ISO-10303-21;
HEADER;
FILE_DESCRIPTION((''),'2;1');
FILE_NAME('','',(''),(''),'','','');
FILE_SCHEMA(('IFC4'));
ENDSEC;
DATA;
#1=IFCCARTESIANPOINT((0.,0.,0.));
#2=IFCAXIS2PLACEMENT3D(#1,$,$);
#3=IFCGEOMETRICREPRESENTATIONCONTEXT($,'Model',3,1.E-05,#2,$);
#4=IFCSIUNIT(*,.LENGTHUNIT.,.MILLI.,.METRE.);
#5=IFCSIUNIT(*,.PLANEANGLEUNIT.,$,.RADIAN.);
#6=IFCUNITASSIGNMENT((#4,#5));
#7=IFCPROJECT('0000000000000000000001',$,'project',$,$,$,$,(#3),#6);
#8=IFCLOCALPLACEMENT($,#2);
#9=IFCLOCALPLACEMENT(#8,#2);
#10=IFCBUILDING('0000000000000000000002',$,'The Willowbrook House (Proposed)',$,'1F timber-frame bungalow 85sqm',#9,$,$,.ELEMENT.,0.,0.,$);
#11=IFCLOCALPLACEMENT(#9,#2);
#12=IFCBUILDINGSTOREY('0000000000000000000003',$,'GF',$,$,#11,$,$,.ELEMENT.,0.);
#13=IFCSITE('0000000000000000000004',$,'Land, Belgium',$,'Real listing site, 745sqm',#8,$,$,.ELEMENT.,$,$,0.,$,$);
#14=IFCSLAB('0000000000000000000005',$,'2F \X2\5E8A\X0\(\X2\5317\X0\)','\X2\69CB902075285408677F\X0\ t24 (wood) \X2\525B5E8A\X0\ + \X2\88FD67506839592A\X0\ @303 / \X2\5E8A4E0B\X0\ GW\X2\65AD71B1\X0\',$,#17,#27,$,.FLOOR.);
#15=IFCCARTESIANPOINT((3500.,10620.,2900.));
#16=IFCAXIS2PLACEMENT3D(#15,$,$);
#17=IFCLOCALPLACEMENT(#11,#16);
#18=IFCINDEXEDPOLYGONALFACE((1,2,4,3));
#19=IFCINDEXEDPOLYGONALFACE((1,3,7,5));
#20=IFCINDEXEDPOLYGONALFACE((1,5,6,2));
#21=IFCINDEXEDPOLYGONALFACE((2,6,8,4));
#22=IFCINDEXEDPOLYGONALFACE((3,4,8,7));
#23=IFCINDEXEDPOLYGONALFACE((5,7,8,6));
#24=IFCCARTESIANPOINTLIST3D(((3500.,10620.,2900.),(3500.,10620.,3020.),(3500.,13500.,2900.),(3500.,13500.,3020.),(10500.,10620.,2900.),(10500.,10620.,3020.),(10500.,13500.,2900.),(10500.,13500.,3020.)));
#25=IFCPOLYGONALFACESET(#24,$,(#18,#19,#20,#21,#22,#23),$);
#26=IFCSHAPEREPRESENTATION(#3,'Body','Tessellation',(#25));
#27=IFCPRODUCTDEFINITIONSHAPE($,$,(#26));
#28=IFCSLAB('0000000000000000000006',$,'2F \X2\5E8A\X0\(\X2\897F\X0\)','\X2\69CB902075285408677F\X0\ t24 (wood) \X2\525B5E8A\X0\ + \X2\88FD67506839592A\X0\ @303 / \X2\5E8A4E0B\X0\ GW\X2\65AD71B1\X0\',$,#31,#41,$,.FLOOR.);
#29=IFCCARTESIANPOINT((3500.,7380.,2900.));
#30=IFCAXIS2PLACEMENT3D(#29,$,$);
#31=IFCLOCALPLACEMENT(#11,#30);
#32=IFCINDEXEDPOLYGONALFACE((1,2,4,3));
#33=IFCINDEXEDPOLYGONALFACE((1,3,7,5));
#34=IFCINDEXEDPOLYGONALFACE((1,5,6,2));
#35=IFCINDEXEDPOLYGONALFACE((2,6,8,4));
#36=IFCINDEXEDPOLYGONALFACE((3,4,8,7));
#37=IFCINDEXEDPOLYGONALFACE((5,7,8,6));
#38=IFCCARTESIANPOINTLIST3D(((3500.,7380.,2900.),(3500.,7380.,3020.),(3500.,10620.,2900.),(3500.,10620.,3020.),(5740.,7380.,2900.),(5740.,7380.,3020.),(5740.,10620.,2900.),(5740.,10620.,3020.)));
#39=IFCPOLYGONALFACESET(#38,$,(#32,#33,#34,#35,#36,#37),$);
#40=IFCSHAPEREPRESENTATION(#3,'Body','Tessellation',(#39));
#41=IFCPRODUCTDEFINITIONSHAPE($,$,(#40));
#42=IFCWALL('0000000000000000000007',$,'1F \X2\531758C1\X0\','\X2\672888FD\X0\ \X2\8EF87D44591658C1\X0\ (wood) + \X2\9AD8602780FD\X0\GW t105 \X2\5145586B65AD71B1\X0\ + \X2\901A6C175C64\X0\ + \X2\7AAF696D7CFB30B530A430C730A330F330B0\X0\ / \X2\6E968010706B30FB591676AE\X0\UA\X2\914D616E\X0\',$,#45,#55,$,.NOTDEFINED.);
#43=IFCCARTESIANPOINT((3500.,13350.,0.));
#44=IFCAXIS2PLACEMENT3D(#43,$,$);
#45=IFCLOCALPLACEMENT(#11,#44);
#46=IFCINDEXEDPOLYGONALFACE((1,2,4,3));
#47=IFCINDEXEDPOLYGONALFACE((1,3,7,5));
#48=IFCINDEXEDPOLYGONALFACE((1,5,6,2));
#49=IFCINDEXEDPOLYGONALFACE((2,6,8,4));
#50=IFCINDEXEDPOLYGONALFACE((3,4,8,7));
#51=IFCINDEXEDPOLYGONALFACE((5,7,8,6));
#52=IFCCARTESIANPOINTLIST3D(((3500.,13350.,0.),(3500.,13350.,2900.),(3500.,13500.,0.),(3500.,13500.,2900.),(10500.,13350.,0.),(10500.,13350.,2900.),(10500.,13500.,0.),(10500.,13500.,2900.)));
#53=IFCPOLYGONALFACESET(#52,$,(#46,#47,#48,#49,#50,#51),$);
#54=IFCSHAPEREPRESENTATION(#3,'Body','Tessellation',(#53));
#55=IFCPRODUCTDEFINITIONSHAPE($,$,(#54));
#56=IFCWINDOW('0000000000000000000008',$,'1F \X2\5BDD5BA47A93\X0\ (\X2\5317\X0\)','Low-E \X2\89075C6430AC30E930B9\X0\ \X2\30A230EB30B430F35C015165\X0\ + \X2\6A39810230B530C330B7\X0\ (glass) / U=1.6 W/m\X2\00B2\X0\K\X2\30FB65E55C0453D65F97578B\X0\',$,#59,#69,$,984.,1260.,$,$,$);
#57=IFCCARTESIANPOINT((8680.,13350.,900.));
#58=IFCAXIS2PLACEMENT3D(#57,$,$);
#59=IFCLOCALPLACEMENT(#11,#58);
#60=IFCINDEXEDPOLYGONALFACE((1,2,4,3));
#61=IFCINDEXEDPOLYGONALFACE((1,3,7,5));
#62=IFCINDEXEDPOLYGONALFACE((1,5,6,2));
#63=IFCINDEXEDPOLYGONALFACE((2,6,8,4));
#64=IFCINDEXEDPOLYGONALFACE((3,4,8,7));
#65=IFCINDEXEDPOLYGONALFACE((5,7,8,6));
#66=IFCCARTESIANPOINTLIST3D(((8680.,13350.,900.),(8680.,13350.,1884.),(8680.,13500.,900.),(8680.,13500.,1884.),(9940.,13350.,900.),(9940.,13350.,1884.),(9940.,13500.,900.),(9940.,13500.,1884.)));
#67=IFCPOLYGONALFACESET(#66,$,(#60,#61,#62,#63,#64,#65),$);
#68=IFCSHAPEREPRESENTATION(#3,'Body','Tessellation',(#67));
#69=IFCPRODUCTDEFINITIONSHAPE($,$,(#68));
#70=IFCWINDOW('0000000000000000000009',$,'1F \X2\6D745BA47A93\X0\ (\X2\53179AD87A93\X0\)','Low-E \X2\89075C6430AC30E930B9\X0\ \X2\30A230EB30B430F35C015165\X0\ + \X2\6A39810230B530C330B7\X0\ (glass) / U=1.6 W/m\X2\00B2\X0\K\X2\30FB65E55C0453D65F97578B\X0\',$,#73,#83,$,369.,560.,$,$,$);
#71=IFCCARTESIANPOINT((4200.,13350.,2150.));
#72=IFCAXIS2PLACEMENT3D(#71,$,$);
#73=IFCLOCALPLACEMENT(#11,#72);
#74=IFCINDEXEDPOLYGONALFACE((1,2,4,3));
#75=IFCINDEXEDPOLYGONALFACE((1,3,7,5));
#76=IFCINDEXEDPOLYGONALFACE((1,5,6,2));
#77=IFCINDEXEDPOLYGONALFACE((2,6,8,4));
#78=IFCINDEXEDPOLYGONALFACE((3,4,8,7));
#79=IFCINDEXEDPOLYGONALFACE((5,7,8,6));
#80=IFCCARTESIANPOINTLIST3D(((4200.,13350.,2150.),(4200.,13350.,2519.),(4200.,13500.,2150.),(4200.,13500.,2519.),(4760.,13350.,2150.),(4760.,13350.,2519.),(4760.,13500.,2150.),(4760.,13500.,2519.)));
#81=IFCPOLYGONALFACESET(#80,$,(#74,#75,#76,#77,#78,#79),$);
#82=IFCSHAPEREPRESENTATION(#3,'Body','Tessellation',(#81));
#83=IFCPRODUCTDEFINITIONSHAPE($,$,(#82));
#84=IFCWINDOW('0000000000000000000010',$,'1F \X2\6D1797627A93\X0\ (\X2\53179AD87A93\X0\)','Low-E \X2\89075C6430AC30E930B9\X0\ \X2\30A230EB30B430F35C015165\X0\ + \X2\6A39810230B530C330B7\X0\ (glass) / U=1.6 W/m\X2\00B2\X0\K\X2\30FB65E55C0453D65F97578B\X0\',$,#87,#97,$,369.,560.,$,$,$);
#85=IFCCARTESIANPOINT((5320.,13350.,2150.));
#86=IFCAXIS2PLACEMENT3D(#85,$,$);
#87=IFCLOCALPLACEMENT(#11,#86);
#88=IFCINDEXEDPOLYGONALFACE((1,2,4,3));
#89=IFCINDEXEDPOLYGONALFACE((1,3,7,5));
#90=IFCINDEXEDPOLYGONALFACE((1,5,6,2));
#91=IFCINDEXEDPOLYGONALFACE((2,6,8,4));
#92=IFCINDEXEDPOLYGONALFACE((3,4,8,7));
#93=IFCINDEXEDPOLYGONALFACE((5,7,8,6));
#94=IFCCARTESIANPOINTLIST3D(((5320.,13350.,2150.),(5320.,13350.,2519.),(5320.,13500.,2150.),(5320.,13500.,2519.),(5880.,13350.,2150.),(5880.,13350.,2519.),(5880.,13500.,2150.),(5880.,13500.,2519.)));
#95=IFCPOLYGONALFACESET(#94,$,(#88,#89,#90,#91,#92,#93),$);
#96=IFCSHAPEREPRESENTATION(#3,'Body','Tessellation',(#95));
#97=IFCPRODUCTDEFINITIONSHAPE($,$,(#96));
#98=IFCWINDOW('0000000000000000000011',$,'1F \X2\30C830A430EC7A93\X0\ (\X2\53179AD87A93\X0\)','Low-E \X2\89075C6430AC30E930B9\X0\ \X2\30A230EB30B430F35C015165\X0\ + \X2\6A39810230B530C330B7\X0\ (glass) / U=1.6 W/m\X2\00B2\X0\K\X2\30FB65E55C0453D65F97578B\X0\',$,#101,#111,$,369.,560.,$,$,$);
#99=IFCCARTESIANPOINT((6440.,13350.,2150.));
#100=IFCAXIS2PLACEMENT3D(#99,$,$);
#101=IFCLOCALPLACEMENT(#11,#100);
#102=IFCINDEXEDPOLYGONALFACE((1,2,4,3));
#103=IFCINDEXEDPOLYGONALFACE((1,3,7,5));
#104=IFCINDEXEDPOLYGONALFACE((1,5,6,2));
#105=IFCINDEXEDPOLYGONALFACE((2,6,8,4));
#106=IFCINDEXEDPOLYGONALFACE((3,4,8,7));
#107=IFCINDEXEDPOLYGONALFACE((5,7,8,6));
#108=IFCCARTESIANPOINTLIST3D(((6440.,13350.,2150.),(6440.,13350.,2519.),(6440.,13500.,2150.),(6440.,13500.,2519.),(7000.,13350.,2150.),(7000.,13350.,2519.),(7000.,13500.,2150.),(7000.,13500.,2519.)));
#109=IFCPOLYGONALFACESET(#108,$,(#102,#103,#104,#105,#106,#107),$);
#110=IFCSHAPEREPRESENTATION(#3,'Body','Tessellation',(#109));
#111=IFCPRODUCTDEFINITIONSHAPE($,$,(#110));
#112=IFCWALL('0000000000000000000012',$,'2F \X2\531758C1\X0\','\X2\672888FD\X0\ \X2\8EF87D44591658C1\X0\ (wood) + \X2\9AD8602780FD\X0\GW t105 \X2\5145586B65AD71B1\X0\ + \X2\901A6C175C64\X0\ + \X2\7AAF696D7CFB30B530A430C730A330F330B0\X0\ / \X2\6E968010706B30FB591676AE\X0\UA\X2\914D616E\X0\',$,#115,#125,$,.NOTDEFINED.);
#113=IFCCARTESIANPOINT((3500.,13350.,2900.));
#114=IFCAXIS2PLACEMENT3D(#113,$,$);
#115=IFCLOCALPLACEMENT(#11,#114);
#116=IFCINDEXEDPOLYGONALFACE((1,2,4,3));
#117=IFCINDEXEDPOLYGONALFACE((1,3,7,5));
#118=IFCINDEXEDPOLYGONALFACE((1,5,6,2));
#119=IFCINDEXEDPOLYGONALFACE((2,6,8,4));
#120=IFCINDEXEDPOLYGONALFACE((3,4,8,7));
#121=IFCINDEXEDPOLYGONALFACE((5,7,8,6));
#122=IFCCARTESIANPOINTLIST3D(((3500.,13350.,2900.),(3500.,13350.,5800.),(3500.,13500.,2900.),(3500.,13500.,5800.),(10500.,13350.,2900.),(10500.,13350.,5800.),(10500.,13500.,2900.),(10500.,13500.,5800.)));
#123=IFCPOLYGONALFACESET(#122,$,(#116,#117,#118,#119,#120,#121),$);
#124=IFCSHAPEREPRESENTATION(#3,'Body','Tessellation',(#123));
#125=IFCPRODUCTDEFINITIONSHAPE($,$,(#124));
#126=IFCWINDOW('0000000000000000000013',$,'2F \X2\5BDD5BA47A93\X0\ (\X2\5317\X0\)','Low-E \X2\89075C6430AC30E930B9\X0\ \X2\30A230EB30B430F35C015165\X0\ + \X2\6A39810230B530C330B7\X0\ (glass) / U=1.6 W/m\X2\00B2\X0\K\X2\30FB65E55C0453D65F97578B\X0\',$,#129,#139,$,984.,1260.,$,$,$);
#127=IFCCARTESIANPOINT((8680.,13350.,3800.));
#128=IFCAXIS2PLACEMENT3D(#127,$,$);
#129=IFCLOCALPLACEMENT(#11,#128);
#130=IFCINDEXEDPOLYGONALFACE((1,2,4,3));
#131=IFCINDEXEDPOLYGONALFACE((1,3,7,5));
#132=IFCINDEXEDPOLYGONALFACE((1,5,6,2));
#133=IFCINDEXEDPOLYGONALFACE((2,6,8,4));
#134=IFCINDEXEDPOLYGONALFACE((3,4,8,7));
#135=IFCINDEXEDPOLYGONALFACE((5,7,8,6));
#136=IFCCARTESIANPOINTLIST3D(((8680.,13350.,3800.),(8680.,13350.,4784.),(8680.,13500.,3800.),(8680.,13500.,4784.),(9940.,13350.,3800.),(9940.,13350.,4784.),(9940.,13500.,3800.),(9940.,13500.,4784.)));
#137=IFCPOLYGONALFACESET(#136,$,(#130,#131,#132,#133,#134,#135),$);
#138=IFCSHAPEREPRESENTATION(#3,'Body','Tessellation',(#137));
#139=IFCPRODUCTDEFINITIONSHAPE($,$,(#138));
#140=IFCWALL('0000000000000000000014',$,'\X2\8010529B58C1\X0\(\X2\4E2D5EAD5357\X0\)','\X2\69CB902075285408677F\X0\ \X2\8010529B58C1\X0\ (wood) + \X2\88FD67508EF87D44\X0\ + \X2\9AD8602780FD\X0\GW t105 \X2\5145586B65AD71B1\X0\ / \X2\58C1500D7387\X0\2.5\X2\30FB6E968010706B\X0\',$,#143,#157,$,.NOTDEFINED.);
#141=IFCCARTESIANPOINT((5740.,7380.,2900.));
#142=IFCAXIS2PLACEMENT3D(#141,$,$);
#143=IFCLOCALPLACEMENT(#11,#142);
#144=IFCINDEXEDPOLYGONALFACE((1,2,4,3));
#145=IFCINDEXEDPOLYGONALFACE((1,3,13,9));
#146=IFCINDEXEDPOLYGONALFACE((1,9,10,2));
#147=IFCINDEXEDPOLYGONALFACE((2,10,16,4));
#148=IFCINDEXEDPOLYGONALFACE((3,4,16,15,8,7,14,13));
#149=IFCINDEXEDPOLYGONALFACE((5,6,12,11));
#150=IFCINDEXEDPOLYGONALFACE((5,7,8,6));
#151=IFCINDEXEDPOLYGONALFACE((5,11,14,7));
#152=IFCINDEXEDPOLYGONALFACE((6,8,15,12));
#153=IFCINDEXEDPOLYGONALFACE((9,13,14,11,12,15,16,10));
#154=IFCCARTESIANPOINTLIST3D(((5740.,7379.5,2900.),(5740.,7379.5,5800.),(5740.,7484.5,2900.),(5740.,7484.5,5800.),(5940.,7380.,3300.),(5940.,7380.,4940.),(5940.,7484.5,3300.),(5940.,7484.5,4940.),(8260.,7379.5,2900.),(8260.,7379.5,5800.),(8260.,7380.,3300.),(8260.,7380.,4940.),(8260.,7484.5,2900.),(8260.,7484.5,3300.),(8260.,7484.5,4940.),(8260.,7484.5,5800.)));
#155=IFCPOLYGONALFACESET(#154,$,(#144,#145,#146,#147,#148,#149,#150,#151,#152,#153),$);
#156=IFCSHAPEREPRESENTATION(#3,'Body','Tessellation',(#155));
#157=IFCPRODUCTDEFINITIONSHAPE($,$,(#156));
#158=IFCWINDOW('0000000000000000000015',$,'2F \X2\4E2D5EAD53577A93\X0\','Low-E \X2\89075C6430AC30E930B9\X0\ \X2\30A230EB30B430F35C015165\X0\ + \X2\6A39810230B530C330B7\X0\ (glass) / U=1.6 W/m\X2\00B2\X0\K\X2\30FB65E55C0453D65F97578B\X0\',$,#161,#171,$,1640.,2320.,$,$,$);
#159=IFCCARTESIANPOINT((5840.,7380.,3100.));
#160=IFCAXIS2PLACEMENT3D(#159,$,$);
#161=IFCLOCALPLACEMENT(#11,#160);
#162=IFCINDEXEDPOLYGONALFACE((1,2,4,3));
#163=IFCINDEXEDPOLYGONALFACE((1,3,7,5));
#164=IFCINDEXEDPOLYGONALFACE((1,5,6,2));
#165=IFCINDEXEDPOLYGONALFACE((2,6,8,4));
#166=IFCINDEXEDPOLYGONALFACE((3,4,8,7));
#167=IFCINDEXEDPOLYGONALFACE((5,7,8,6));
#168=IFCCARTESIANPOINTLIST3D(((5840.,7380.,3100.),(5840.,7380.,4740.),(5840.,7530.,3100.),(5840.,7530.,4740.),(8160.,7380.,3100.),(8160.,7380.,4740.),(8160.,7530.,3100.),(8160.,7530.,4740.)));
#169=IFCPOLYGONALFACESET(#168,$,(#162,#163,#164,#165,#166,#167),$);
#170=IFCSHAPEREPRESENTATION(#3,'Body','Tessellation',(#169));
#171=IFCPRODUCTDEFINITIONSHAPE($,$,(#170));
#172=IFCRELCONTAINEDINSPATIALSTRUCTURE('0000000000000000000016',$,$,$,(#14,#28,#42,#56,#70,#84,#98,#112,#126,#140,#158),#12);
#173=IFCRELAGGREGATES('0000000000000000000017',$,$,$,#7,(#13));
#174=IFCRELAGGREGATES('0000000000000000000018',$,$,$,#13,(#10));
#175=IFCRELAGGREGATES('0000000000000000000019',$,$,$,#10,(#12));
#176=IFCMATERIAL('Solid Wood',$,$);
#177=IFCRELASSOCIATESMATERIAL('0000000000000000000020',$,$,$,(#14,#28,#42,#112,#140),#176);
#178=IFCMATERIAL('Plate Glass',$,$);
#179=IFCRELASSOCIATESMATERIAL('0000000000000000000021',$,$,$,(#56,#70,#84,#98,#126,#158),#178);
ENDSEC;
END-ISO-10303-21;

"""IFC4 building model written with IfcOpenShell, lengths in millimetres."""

from ifc_helpers import new_model, si_unit, frame, frame_2d, origin, place, context, project, spatial, rectangle, extrude, material, element, fill, save


model = new_model("IFC4")

# Units and contexts
model_context = context("Model", 3, precision=1e-05, world=origin())
ifc_project = project(units=[si_unit("LENGTHUNIT", "METRE", prefix="MILLI"), si_unit("PLANEANGLEUNIT", "RADIAN")], contexts=[model_context])

# Site, building, storey
site_placement = place(None, origin())
site = spatial("IfcSite", under=ifc_project, at=site_placement, Name="Land, Belgium", ObjectType="Real listing site, 745sqm", CompositionType="ELEMENT", RefElevation=0.0)
building_placement = place(site_placement, origin())
building = spatial("IfcBuilding", under=site, at=building_placement, Name="The Willowbrook House (Proposed)", ObjectType="1F timber-frame bungalow 85sqm", CompositionType="ELEMENT", ElevationOfRefHeight=0.0, ElevationOfTerrain=0.0)
storey_placement = place(building_placement, origin())
storey = spatial("IfcBuildingStorey", under=building, at=storey_placement, Name="GF", CompositionType="ELEMENT", Elevation=0.0)

# Slabs
ifc_material_1 = material(Name="Solid Wood")
slab_1_placement = place(storey_placement, frame((3500.0, 10620.0, 2900.0)))
element("IfcSlab", 1, at=slab_1_placement, inside=storey, material=ifc_material_1, Name="2F 床(北)", Description="構造用合板 t24 (wood) 剛床 + 製材根太 @303 / 床下 GW断熱", PredefinedType="FLOOR", context=model_context, shape_type="SweptSolid", body=[
    extrude(rectangle(XDim=7000.0, YDim=2880.0, at=frame_2d((3500.0, 1440.0))), frame((3500.0, 10620.0, 2900.0)), (0.0, 0.0, 1.0), 120.0),
])
slab_2_placement = place(storey_placement, frame((3500.0, 7380.0, 2900.0)))
element("IfcSlab", 2, at=slab_2_placement, inside=storey, material=ifc_material_1, Name="2F 床(西)", Description="構造用合板 t24 (wood) 剛床 + 製材根太 @303 / 床下 GW断熱", PredefinedType="FLOOR", context=model_context, shape_type="SweptSolid", body=[
    extrude(rectangle(XDim=2240.0, YDim=3240.0, at=frame_2d((1120.0, 1620.0))), frame((3500.0, 7380.0, 2900.0)), (0.0, 0.0, 1.0), 120.0),
])

# Wall, openings, windows
wall_1_placement = place(storey_placement, frame((3500.0, 13350.0, 0.0)))
wall_1 = element("IfcWall", 3, at=wall_1_placement, inside=storey, material=ifc_material_1, Name="1F 北壁", Description="木製 軸組外壁 (wood) + 高性能GW t105 充填断熱 + 通気層 + 窯業系サイディング / 準耐火・外皮UA配慮", PredefinedType="NOTDEFINED", context=model_context, shape_type="SweptSolid", body=[
    extrude(rectangle(XDim=7000.0, YDim=150.0, at=frame_2d((3500.0, 75.0))), frame((3500.0, 13350.0, 0.0)), (0.0, 0.0, 1.0), 2900.0),
])
opening_1_placement = place(storey_placement, frame((8680.0, 13350.0, 900.0)))
opening_1 = element("IfcOpeningElement", 4, at=opening_1_placement, cuts=wall_1, PredefinedType="NOTDEFINED", context=model_context, shape_type="SweptSolid", body=[
    extrude(rectangle(XDim=1260.0, YDim=150.0, at=frame_2d((630.0, 75.0))), frame((8680.0, 13350.0, 900.0)), (0.0, 0.0, 1.0), 984.0),
])
opening_2_placement = place(storey_placement, frame((4200.0, 13350.0, 2150.0)))
opening_2 = element("IfcOpeningElement", 5, at=opening_2_placement, cuts=wall_1, PredefinedType="NOTDEFINED", context=model_context, shape_type="SweptSolid", body=[
    extrude(rectangle(XDim=560.0, YDim=150.0, at=frame_2d((280.0, 75.0))), frame((4200.0, 13350.0, 2150.0)), (0.0, 0.0, 1.0), 369.0),
])
opening_3_placement = place(storey_placement, frame((5320.0, 13350.0, 2150.0)))
opening_3 = element("IfcOpeningElement", 6, at=opening_3_placement, cuts=wall_1, PredefinedType="NOTDEFINED", context=model_context, shape_type="SweptSolid", body=[
    extrude(rectangle(XDim=560.0, YDim=150.0, at=frame_2d((280.0, 75.0))), frame((5320.0, 13350.0, 2150.0)), (0.0, 0.0, 1.0), 369.0),
])
opening_4_placement = place(storey_placement, frame((6440.0, 13350.0, 2150.0)))
opening_4 = element("IfcOpeningElement", 7, at=opening_4_placement, cuts=wall_1, PredefinedType="NOTDEFINED", context=model_context, shape_type="SweptSolid", body=[
    extrude(rectangle(XDim=560.0, YDim=150.0, at=frame_2d((280.0, 75.0))), frame((6440.0, 13350.0, 2150.0)), (0.0, 0.0, 1.0), 369.0),
])
ifc_material_2 = material(Name="Plate Glass")
window_1_placement = place(storey_placement, frame((8680.0, 13350.0, 900.0)))
window_1 = element("IfcWindow", 8, at=window_1_placement, inside=storey, material=ifc_material_2, Name="1F 寝室窓 (北)", Description="Low-E 複層ガラス アルゴン封入 + 樹脂サッシ (glass) / U=1.6 W/m²K・日射取得型", OverallHeight=984.0, OverallWidth=1260.0, context=model_context, shape_type="SweptSolid", body=[
    extrude(rectangle(XDim=1260.0, YDim=150.0, at=frame_2d((630.0, 75.0))), frame((8680.0, 13350.0, 900.0)), (0.0, 0.0, 1.0), 984.0),
])
fill(opening_1, window_1)
window_2_placement = place(storey_placement, frame((4200.0, 13350.0, 2150.0)))
window_2 = element("IfcWindow", 9, at=window_2_placement, inside=storey, material=ifc_material_2, Name="1F 浴室窓 (北高窓)", Description="Low-E 複層ガラス アルゴン封入 + 樹脂サッシ (glass) / U=1.6 W/m²K・日射取得型", OverallHeight=369.0, OverallWidth=560.0, context=model_context, shape_type="SweptSolid", body=[
    extrude(rectangle(XDim=560.0, YDim=150.0, at=frame_2d((280.0, 75.0))), frame((4200.0, 13350.0, 2150.0)), (0.0, 0.0, 1.0), 369.0),
])
fill(opening_2, window_2)
window_3_placement = place(storey_placement, frame((5320.0, 13350.0, 2150.0)))
window_3 = element("IfcWindow", 10, at=window_3_placement, inside=storey, material=ifc_material_2, Name="1F 洗面窓 (北高窓)", Description="Low-E 複層ガラス アルゴン封入 + 樹脂サッシ (glass) / U=1.6 W/m²K・日射取得型", OverallHeight=369.0, OverallWidth=560.0, context=model_context, shape_type="SweptSolid", body=[
    extrude(rectangle(XDim=560.0, YDim=150.0, at=frame_2d((280.0, 75.0))), frame((5320.0, 13350.0, 2150.0)), (0.0, 0.0, 1.0), 369.0),
])
fill(opening_3, window_3)
window_4_placement = place(storey_placement, frame((6440.0, 13350.0, 2150.0)))
window_4 = element("IfcWindow", 11, at=window_4_placement, inside=storey, material=ifc_material_2, Name="1F トイレ窓 (北高窓)", Description="Low-E 複層ガラス アルゴン封入 + 樹脂サッシ (glass) / U=1.6 W/m²K・日射取得型", OverallHeight=369.0, OverallWidth=560.0, context=model_context, shape_type="SweptSolid", body=[
    extrude(rectangle(XDim=560.0, YDim=150.0, at=frame_2d((280.0, 75.0))), frame((6440.0, 13350.0, 2150.0)), (0.0, 0.0, 1.0), 369.0),
])
fill(opening_4, window_4)

# Walls, openings, windows
wall_2_placement = place(storey_placement, frame((3500.0, 13350.0, 2900.0)))
wall_2 = element("IfcWall", 12, at=wall_2_placement, inside=storey, material=ifc_material_1, Name="2F 北壁", Description="木製 軸組外壁 (wood) + 高性能GW t105 充填断熱 + 通気層 + 窯業系サイディング / 準耐火・外皮UA配慮", PredefinedType="NOTDEFINED", context=model_context, shape_type="SweptSolid", body=[
    extrude(rectangle(XDim=7000.0, YDim=150.0, at=frame_2d((3500.0, 75.0))), frame((3500.0, 13350.0, 2900.0)), (0.0, 0.0, 1.0), 2900.0),
])
opening_5_placement = place(storey_placement, frame((8680.0, 13350.0, 3800.0)))
opening_5 = element("IfcOpeningElement", 13, at=opening_5_placement, cuts=wall_2, PredefinedType="NOTDEFINED", context=model_context, shape_type="SweptSolid", body=[
    extrude(rectangle(XDim=1260.0, YDim=150.0, at=frame_2d((630.0, 75.0))), frame((8680.0, 13350.0, 3800.0)), (0.0, 0.0, 1.0), 984.0),
])
window_5_placement = place(storey_placement, frame((8680.0, 13350.0, 3800.0)))
window_5 = element("IfcWindow", 14, at=window_5_placement, inside=storey, material=ifc_material_2, Name="2F 寝室窓 (北)", Description="Low-E 複層ガラス アルゴン封入 + 樹脂サッシ (glass) / U=1.6 W/m²K・日射取得型", OverallHeight=984.0, OverallWidth=1260.0, context=model_context, shape_type="SweptSolid", body=[
    extrude(rectangle(XDim=1260.0, YDim=150.0, at=frame_2d((630.0, 75.0))), frame((8680.0, 13350.0, 3800.0)), (0.0, 0.0, 1.0), 984.0),
])
fill(opening_5, window_5)
wall_3_placement = place(storey_placement, frame((5740.0, 7380.0, 2900.0)))
wall_3 = element("IfcWall", 15, at=wall_3_placement, inside=storey, material=ifc_material_1, Name="耐力壁(中庭南)", Description="構造用合板 耐力壁 (wood) + 製材軸組 + 高性能GW t105 充填断熱 / 壁倍率2.5・準耐火", PredefinedType="NOTDEFINED", context=model_context, shape_type="SweptSolid", body=[
    extrude(rectangle(XDim=2520.0, YDim=105.0, at=frame_2d((1260.0, 52.0))), frame((5740.0, 7380.0, 2900.0)), (0.0, 0.0, 1.0), 2900.0),
])
opening_6_placement = place(storey_placement, frame((5840.0, 7380.0, 3100.0)))
opening_6 = element("IfcOpeningElement", 16, at=opening_6_placement, cuts=wall_3, PredefinedType="NOTDEFINED", context=model_context, shape_type="SweptSolid", body=[
    extrude(rectangle(XDim=2320.0, YDim=150.0, at=frame_2d((1160.0, 75.0))), frame((5840.0, 7380.0, 3100.0)), (0.0, 0.0, 1.0), 1640.0),
])
window_6_placement = place(storey_placement, frame((5840.0, 7380.0, 3100.0)))
window_6 = element("IfcWindow", 17, at=window_6_placement, inside=storey, material=ifc_material_2, Name="2F 中庭南窓", Description="Low-E 複層ガラス アルゴン封入 + 樹脂サッシ (glass) / U=1.6 W/m²K・日射取得型", OverallHeight=1640.0, OverallWidth=2320.0, context=model_context, shape_type="SweptSolid", body=[
    extrude(rectangle(XDim=2320.0, YDim=150.0, at=frame_2d((1160.0, 75.0))), frame((5840.0, 7380.0, 3100.0)), (0.0, 0.0, 1.0), 1640.0),
])
fill(opening_6, window_6)

save(model, "model.ifc")
